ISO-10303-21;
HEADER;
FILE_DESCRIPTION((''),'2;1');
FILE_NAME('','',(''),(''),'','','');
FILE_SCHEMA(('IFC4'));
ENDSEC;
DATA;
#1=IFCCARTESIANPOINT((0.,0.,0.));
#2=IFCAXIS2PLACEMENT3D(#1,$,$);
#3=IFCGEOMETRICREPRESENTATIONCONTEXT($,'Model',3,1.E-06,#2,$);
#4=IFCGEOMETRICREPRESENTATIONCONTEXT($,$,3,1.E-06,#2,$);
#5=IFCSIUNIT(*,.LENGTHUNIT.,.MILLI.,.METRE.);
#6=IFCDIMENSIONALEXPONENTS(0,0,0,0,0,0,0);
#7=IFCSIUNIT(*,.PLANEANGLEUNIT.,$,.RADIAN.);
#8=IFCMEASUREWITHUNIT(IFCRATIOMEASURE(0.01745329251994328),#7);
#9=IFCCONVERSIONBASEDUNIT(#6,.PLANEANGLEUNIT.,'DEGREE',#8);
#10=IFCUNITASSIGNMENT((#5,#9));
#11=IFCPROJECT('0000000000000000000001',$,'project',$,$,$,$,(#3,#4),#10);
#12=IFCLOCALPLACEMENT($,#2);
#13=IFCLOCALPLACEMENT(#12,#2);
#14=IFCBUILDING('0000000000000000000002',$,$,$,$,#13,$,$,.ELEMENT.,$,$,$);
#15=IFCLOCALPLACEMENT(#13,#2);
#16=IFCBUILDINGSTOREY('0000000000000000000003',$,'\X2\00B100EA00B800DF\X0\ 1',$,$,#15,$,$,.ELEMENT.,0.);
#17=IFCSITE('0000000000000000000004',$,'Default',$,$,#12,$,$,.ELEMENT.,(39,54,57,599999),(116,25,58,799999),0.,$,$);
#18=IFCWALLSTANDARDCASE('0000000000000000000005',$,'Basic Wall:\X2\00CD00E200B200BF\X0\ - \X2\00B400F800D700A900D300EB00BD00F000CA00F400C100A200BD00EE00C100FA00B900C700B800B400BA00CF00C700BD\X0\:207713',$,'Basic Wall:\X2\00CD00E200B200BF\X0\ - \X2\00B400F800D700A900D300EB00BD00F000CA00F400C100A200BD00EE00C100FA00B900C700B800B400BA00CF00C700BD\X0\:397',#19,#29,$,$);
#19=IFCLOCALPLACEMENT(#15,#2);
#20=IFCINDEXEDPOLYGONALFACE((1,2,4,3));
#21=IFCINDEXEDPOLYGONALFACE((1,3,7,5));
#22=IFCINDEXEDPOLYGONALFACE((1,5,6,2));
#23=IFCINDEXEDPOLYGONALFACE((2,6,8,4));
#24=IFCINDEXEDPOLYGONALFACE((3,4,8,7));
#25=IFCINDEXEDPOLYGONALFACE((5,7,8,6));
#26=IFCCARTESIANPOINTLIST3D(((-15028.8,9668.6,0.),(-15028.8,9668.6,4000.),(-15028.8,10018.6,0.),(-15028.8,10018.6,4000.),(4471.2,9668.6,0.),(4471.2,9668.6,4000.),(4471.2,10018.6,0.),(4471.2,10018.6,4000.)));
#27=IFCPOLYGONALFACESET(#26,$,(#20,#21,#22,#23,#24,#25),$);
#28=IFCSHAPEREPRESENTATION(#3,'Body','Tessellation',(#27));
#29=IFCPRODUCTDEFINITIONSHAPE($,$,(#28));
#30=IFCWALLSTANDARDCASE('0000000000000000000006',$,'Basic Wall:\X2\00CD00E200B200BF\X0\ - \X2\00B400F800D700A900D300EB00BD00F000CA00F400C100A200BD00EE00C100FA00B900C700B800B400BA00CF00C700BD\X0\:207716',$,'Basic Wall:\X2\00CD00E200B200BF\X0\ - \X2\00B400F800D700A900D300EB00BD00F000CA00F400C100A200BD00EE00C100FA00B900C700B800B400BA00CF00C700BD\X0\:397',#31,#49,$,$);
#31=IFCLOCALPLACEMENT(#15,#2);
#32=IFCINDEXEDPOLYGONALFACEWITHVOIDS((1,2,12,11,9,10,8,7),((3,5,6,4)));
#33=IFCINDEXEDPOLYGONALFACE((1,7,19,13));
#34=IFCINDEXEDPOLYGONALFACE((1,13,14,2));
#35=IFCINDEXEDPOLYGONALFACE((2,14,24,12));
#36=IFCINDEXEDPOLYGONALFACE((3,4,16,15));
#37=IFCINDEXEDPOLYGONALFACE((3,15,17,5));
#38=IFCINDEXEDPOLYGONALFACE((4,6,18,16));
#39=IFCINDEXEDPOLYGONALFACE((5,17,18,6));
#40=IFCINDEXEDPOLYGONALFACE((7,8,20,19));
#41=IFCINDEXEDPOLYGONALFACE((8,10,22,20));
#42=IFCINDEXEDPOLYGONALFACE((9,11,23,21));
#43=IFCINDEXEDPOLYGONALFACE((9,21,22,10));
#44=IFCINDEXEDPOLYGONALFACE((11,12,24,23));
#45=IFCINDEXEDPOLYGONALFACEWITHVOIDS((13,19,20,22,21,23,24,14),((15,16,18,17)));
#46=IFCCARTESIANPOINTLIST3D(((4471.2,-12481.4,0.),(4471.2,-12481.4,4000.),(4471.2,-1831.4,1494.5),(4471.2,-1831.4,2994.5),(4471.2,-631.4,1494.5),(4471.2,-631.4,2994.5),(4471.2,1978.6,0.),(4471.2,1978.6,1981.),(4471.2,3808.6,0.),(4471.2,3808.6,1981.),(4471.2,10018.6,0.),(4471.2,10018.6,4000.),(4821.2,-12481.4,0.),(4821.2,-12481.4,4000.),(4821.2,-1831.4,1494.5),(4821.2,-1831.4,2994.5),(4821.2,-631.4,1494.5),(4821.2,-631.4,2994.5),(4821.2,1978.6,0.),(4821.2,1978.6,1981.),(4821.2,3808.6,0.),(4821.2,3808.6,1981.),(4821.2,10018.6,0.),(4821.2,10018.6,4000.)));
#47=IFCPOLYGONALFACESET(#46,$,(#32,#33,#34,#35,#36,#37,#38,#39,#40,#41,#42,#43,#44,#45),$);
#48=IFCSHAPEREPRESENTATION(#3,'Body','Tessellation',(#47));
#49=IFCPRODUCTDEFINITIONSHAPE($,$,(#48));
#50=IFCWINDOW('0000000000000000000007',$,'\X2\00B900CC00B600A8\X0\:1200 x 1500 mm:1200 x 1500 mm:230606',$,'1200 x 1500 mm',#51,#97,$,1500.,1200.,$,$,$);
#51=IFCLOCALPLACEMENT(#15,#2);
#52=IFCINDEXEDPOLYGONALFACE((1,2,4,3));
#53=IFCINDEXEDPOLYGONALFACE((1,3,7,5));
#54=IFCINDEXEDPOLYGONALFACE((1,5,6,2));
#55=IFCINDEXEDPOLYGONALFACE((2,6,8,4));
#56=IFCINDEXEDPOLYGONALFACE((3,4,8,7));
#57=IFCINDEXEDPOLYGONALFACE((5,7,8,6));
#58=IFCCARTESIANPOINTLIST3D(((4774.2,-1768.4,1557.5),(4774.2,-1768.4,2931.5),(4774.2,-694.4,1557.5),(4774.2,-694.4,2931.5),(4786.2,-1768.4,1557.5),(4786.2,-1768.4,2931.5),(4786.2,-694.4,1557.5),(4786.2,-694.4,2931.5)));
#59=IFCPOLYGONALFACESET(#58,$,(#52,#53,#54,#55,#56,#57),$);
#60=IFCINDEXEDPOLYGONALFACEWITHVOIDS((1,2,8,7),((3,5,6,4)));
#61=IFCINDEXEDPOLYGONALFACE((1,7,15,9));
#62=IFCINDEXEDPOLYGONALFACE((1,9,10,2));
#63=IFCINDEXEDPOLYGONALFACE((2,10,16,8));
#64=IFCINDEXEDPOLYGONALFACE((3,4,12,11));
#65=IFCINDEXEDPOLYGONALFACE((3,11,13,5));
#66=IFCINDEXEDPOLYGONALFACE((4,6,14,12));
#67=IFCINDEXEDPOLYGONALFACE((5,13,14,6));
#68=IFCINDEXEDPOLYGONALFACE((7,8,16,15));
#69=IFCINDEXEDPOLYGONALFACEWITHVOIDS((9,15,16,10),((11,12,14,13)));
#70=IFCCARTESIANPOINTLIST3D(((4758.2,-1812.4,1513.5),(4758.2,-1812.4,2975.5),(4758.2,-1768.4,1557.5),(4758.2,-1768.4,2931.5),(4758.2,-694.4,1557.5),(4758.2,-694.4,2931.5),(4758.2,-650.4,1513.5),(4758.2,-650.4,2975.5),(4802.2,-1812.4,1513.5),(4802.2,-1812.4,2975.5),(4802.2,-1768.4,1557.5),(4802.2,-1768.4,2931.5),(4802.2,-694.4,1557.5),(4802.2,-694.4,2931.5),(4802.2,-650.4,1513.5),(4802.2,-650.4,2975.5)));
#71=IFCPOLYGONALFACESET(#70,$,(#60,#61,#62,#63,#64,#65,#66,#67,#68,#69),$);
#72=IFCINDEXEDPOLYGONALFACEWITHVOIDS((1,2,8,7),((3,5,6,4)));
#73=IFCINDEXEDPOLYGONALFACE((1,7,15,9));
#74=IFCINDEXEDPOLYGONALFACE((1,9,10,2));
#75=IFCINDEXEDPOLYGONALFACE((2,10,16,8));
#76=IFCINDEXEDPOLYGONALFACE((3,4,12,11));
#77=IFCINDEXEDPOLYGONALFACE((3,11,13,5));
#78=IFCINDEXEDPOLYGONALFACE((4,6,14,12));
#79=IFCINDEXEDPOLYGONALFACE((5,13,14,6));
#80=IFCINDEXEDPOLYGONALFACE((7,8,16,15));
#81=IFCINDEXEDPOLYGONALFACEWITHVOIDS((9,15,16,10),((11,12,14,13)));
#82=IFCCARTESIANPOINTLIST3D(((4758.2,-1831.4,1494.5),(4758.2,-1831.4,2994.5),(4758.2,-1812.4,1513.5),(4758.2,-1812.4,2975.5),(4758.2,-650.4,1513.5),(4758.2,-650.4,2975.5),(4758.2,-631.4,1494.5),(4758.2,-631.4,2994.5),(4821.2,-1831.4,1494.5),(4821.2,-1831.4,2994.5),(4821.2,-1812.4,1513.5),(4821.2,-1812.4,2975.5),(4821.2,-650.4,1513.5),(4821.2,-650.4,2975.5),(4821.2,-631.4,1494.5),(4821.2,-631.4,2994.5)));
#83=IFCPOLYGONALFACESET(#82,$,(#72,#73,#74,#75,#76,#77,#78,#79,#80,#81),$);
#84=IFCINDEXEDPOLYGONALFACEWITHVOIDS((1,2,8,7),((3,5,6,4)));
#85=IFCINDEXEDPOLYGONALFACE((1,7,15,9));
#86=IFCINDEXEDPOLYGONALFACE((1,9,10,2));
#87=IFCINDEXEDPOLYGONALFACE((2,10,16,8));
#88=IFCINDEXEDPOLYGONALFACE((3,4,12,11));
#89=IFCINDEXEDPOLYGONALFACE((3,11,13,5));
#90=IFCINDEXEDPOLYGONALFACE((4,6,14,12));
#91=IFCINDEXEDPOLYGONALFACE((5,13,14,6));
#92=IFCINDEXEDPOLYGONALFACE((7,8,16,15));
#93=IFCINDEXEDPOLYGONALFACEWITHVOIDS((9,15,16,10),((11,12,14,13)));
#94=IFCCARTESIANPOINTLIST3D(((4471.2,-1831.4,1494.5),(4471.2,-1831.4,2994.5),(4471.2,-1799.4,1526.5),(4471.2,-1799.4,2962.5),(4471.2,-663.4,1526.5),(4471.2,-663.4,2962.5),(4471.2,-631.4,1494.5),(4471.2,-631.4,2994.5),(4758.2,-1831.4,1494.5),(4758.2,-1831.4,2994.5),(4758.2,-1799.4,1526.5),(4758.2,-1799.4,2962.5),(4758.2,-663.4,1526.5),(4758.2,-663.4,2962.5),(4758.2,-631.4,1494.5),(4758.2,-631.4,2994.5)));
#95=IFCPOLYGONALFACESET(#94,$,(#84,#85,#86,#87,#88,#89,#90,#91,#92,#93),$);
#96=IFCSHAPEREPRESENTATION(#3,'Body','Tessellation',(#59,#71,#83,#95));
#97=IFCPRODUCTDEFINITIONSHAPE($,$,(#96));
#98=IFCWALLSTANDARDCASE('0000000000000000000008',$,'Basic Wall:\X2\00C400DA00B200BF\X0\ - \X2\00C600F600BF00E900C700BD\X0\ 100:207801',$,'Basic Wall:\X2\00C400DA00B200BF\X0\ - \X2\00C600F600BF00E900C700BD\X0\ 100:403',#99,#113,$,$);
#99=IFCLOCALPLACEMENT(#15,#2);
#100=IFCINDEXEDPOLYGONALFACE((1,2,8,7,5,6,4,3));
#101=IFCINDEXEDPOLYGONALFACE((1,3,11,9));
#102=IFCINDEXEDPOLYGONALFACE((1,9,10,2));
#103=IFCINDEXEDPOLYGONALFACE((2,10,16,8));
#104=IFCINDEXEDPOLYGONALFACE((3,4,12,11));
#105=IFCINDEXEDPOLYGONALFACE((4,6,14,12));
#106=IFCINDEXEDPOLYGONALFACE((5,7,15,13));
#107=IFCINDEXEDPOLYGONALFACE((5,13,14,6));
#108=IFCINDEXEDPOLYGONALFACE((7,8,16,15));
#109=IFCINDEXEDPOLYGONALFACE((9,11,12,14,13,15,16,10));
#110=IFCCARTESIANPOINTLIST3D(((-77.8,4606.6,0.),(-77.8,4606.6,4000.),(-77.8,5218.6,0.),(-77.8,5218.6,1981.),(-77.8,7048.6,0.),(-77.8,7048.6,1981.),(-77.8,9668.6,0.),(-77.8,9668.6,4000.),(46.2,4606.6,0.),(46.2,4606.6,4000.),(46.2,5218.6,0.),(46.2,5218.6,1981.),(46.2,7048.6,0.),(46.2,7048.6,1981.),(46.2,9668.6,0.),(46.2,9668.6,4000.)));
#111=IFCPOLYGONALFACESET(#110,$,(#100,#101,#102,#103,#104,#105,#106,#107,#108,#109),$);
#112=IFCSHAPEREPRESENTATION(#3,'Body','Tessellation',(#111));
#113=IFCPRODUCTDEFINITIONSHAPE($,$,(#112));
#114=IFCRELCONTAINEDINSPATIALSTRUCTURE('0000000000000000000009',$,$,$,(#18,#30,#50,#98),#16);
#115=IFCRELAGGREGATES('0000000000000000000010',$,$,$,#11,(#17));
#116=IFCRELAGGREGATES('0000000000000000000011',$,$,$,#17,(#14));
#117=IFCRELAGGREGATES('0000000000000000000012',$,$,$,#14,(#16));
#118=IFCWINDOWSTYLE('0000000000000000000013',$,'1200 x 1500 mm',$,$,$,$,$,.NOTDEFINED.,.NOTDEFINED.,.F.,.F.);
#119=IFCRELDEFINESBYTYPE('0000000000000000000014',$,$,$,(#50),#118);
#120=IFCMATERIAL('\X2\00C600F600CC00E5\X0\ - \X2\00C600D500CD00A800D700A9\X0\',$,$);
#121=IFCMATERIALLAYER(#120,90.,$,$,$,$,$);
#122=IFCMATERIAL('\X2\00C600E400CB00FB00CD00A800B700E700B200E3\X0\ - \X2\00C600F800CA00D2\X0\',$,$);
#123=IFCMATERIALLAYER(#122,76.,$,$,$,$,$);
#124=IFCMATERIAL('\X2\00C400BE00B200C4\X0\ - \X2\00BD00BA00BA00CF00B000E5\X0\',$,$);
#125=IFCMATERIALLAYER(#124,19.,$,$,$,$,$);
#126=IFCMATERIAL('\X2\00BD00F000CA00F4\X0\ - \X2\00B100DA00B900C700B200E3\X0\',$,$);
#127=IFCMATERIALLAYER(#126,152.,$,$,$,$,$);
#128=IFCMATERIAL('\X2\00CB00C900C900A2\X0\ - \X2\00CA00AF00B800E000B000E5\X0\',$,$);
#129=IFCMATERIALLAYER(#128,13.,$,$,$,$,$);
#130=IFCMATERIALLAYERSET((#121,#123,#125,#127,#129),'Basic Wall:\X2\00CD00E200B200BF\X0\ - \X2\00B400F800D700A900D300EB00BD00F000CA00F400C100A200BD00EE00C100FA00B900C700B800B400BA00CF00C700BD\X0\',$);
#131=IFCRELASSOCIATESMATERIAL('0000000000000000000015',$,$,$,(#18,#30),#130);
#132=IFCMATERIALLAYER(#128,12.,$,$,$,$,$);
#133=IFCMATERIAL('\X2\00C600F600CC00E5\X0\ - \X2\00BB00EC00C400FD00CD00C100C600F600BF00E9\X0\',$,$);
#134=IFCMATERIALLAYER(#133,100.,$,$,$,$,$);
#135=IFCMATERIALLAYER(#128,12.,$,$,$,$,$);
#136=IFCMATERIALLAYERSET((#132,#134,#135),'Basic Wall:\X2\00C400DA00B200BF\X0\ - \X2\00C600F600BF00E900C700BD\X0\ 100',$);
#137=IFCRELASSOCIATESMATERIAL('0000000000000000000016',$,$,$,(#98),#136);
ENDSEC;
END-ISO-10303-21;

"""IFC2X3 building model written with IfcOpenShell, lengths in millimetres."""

from ifc_helpers import new_model, entity, si_unit, converted_unit, frame, frame_2d, origin, origin_2d_with_axis, place, context, project, spatial, polyline, rectangle, outline, extrude, source, transform, mapped, material, layer, layer_set, layer_usage, type_object, type_shapes, element, fill, save


model = new_model("IFC2X3")

# Units and contexts
model_context = context("Model", 3, precision=1e-06, world=origin())
context_of_model = context(None, 3, precision=1e-06, world=origin())
ifc_project = project(units=[si_unit("LENGTHUNIT", "METRE", prefix="MILLI"), converted_unit("PLANEANGLEUNIT", "DEGREE", entity("IfcRatioMeasure", 0.01745329251994328), si_unit("PLANEANGLEUNIT", "RADIAN"), dimensions=[0, 0, 0, 0, 0, 0, 0])], contexts=[model_context, context_of_model])

# Site, building, storey
site_placement = place(None, origin())
site = spatial("IfcSite", under=ifc_project, at=site_placement, Name="Default", CompositionType="ELEMENT", RefLatitude=(39, 54, 57, 599999), RefLongitude=(116, 25, 58, 799999), RefElevation=0.0)
building_placement = place(site_placement, origin())
building = spatial("IfcBuilding", under=site, at=building_placement, CompositionType="ELEMENT")
storey_placement = place(building_placement, origin())
storey = spatial("IfcBuildingStorey", under=building, at=storey_placement, Name="±ê¸ß 1", CompositionType="ELEMENT", Elevation=0.0)

# Wall
ifc_material_1 = material(Name="ÆöÌå - ÆÕÍ¨×©")
ifc_layer_1 = layer(ifc_material_1, 90.0)
ifc_material_2 = material(Name="ÆäËûÍ¨·ç²ã - ÆøÊÒ")
ifc_layer_2 = layer(ifc_material_2, 76.0)
ifc_material_3 = material(Name="Ä¾²Ä - ½ººÏ°å")
ifc_layer_3 = layer(ifc_material_3, 19.0)
ifc_material_4 = material(Name="½ðÊô - ±Ú¹Ç²ã")
ifc_layer_4 = layer(ifc_material_4, 152.0)
ifc_material_5 = material(Name="ËÉÉ¢ - Ê¯¸à°å")
ifc_layer_5 = layer(ifc_material_5, 13.0)
ifc_layer_set_1 = layer_set([ifc_layer_1, ifc_layer_2, ifc_layer_3, ifc_layer_4, ifc_layer_5], Name="Basic Wall:Íâ²¿ - ´ø×©Óë½ðÊôÁ¢½îÁú¹Ç¸´ºÏÇ½")
ifc_layer_usage_1 = layer_usage(ifc_layer_set_1, "AXIS2", "NEGATIVE", 175.0)
wall_1_placement = place(storey_placement, frame((-15028.8, 9843.6, 0.0)))
element("IfcWallStandardCase", 1, at=wall_1_placement, inside=storey, material=ifc_layer_usage_1, Name="Basic Wall:Íâ²¿ - ´ø×©Óë½ðÊôÁ¢½îÁú¹Ç¸´ºÏÇ½:207713", ObjectType="Basic Wall:Íâ²¿ - ´ø×©Óë½ðÊôÁ¢½îÁú¹Ç¸´ºÏÇ½:397", context=model_context, shape_type="SweptSolid", body=[
    extrude(rectangle(XDim=19500.0, YDim=350.0, at=frame_2d((9750.0, 0.0), x_axis=(-1.0, 0.0))), origin(), (0.0, 0.0, 1.0), 4000.0),
])

# Wall, openings, window
ifc_layer_usage_2 = layer_usage(ifc_layer_set_1, "AXIS2", "NEGATIVE", 175.0)
wall_2_placement = place(storey_placement, frame((4646.2, 10018.6, 0.0), z_axis=(0.0, 0.0, 1.0), x_axis=(0.0, -1.0, 0.0)))
wall_2 = element("IfcWallStandardCase", 2, at=wall_2_placement, inside=storey, material=ifc_layer_usage_2, Name="Basic Wall:Íâ²¿ - ´ø×©Óë½ðÊôÁ¢½îÁú¹Ç¸´ºÏÇ½:207716", ObjectType="Basic Wall:Íâ²¿ - ´ø×©Óë½ðÊôÁ¢½îÁú¹Ç¸´ºÏÇ½:397", context=model_context, shape_type="SweptSolid", body=[
    extrude(rectangle(XDim=22500.0, YDim=350.0, at=frame_2d((11250.0, 0.0), x_axis=(-1.0, 0.0))), origin(), (0.0, 0.0, 1.0), 4000.0),
])
opening_1_placement = place(wall_2_placement, frame((10650.0, -175.0, 1494.5)))
opening_1 = element("IfcOpeningElement", 3, at=opening_1_placement, cuts=wall_2, ObjectType="Opening", context=model_context, shape_type="SweptSolid", body=[
    extrude(rectangle(XDim=1500.0, YDim=1200.0, at=frame_2d((750.0, 600.0), x_axis=(1.0, 0.0))), frame((0.0, 0.0, 0.0), z_axis=(0.0, 1.0, 0.0), x_axis=(0.0, 0.0, 1.0)), (0.0, 0.0, 1.0), 350.0),
])
opening_2_placement = place(wall_2_placement, frame((8040.0, 175.0, 0.0)))
element("IfcOpeningElement", 4, at=opening_2_placement, cuts=wall_2, ObjectType="Opening", context=model_context, shape_type="SweptSolid", body=[
    extrude(rectangle(XDim=1981.0, YDim=1830.0, at=frame_2d((990.5, 915.0), x_axis=(1.0, 0.0))), frame((0.0, 0.0, 0.0), z_axis=(0.0, -1.0, 0.0), x_axis=(0.0, 0.0, 1.0)), (0.0, 0.0, 1.0), 350.0),
])
window_style_1 = type_object("IfcWindowStyle", Name="1200 x 1500 mm", ConstructionType="NOTDEFINED", OperationType="NOTDEFINED", ParameterTakesPrecedence=False, Sizeable=False)
shared_shape_1 = source(origin(), model_context, "Body", "SweptSolid", [
    extrude(rectangle(XDim=12.0, YDim=1074.0, at=origin_2d_with_axis()), frame((600.0, 309.0, 63.0), z_axis=(0.0, 0.0, 1.0), x_axis=(0.0, -1.0, 0.0)), (0.0, 0.0, 1.0), 1374.0),
    extrude(outline(polyline([(-581.0, -731.0), (581.0, -731.0), (581.0, 731.0), (-581.0, 731.0), (-581.0, -731.0)]), holes=[polyline([(-537.0, -687.0), (-537.0, 687.0), (537.0, 687.0), (537.0, -687.0), (-537.0, -687.0)])]), frame((600.0, 287.0, 750.0), z_axis=(0.0, 1.0, 0.0), x_axis=(1.0, 0.0, 0.0)), (0.0, 0.0, 1.0), 44.0),
    extrude(outline(polyline([(-600.0, -750.0), (600.0, -750.0), (600.0, 750.0), (-600.0, 750.0), (-600.0, -750.0)]), holes=[polyline([(-581.0, -731.0), (-581.0, 731.0), (581.0, 731.0), (581.0, -731.0), (-581.0, -731.0)])]), frame((600.0, 287.0, 750.0), z_axis=(0.0, 1.0, 0.0), x_axis=(1.0, 0.0, 0.0)), (0.0, 0.0, 1.0), 63.0),
    extrude(outline(polyline([(-600.0, -750.0), (600.0, -750.0), (600.0, 750.0), (-600.0, 750.0), (-600.0, -750.0)]), holes=[polyline([(-568.0, -718.0), (-568.0, 718.0), (568.0, 718.0), (568.0, -718.0), (-568.0, -718.0)])]), frame((600.0, 0.0, 750.0), z_axis=(0.0, 1.0, 0.0), x_axis=(1.0, 0.0, 0.0)), (0.0, 0.0, 1.0), 287.0),
])
type_shapes(window_style_1, [shared_shape_1])
window_1_placement = place(opening_1_placement, origin())
window_1 = element("IfcWindow", 5, at=window_1_placement, inside=storey, type_object=window_style_1, Name="¹Ì¶¨:1200 x 1500 mm:1200 x 1500 mm:230606", ObjectType="1200 x 1500 mm", OverallHeight=1500.0, OverallWidth=1200.0, context=model_context, shape_type="MappedRepresentation", body=[
    mapped(shared_shape_1, transform((0.0, 0.0, 0.0), scale=1.0)),
])
fill(opening_1, window_1)

# Wall, opening
ifc_layer_6 = layer(ifc_material_5, 12.0)
ifc_material_6 = material(Name="ÆöÌå - »ìÄýÍÁÆö¿é")
ifc_layer_7 = layer(ifc_material_6, 100.0)
ifc_layer_8 = layer(ifc_material_5, 12.0)
ifc_layer_set_2 = layer_set([ifc_layer_6, ifc_layer_7, ifc_layer_8], Name="Basic Wall:ÄÚ²¿ - Æö¿éÇ½ 100")
ifc_layer_usage_3 = layer_usage(ifc_layer_set_2, "AXIS2", "NEGATIVE", 62.0)
wall_3_placement = place(storey_placement, frame((-15.8, 9668.6, 0.0), z_axis=(0.0, 0.0, 1.0), x_axis=(0.0, -1.0, 0.0)))
wall_3 = element("IfcWallStandardCase", 6, at=wall_3_placement, inside=storey, material=ifc_layer_usage_3, Name="Basic Wall:ÄÚ²¿ - Æö¿éÇ½ 100:207801", ObjectType="Basic Wall:ÄÚ²¿ - Æö¿éÇ½ 100:403", context=model_context, shape_type="SweptSolid", body=[
    extrude(rectangle(XDim=5062.0, YDim=124.0, at=frame_2d((2531.0, 0.0), x_axis=(-1.0, 0.0))), origin(), (0.0, 0.0, 1.0), 4000.0),
])
opening_3_placement = place(wall_3_placement, frame((4450.0, 62.0, 0.0)))
element("IfcOpeningElement", 7, at=opening_3_placement, cuts=wall_3, ObjectType="Opening", context=model_context, shape_type="SweptSolid", body=[
    extrude(rectangle(XDim=1981.0, YDim=1830.0, at=frame_2d((990.5, 915.0), x_axis=(1.0, 0.0))), frame((0.0, 0.0, 0.0), z_axis=(0.0, -1.0, 0.0), x_axis=(0.0, 0.0, 1.0)), (0.0, 0.0, 1.0), 124.0),
])

save(model, "model.ifc")
